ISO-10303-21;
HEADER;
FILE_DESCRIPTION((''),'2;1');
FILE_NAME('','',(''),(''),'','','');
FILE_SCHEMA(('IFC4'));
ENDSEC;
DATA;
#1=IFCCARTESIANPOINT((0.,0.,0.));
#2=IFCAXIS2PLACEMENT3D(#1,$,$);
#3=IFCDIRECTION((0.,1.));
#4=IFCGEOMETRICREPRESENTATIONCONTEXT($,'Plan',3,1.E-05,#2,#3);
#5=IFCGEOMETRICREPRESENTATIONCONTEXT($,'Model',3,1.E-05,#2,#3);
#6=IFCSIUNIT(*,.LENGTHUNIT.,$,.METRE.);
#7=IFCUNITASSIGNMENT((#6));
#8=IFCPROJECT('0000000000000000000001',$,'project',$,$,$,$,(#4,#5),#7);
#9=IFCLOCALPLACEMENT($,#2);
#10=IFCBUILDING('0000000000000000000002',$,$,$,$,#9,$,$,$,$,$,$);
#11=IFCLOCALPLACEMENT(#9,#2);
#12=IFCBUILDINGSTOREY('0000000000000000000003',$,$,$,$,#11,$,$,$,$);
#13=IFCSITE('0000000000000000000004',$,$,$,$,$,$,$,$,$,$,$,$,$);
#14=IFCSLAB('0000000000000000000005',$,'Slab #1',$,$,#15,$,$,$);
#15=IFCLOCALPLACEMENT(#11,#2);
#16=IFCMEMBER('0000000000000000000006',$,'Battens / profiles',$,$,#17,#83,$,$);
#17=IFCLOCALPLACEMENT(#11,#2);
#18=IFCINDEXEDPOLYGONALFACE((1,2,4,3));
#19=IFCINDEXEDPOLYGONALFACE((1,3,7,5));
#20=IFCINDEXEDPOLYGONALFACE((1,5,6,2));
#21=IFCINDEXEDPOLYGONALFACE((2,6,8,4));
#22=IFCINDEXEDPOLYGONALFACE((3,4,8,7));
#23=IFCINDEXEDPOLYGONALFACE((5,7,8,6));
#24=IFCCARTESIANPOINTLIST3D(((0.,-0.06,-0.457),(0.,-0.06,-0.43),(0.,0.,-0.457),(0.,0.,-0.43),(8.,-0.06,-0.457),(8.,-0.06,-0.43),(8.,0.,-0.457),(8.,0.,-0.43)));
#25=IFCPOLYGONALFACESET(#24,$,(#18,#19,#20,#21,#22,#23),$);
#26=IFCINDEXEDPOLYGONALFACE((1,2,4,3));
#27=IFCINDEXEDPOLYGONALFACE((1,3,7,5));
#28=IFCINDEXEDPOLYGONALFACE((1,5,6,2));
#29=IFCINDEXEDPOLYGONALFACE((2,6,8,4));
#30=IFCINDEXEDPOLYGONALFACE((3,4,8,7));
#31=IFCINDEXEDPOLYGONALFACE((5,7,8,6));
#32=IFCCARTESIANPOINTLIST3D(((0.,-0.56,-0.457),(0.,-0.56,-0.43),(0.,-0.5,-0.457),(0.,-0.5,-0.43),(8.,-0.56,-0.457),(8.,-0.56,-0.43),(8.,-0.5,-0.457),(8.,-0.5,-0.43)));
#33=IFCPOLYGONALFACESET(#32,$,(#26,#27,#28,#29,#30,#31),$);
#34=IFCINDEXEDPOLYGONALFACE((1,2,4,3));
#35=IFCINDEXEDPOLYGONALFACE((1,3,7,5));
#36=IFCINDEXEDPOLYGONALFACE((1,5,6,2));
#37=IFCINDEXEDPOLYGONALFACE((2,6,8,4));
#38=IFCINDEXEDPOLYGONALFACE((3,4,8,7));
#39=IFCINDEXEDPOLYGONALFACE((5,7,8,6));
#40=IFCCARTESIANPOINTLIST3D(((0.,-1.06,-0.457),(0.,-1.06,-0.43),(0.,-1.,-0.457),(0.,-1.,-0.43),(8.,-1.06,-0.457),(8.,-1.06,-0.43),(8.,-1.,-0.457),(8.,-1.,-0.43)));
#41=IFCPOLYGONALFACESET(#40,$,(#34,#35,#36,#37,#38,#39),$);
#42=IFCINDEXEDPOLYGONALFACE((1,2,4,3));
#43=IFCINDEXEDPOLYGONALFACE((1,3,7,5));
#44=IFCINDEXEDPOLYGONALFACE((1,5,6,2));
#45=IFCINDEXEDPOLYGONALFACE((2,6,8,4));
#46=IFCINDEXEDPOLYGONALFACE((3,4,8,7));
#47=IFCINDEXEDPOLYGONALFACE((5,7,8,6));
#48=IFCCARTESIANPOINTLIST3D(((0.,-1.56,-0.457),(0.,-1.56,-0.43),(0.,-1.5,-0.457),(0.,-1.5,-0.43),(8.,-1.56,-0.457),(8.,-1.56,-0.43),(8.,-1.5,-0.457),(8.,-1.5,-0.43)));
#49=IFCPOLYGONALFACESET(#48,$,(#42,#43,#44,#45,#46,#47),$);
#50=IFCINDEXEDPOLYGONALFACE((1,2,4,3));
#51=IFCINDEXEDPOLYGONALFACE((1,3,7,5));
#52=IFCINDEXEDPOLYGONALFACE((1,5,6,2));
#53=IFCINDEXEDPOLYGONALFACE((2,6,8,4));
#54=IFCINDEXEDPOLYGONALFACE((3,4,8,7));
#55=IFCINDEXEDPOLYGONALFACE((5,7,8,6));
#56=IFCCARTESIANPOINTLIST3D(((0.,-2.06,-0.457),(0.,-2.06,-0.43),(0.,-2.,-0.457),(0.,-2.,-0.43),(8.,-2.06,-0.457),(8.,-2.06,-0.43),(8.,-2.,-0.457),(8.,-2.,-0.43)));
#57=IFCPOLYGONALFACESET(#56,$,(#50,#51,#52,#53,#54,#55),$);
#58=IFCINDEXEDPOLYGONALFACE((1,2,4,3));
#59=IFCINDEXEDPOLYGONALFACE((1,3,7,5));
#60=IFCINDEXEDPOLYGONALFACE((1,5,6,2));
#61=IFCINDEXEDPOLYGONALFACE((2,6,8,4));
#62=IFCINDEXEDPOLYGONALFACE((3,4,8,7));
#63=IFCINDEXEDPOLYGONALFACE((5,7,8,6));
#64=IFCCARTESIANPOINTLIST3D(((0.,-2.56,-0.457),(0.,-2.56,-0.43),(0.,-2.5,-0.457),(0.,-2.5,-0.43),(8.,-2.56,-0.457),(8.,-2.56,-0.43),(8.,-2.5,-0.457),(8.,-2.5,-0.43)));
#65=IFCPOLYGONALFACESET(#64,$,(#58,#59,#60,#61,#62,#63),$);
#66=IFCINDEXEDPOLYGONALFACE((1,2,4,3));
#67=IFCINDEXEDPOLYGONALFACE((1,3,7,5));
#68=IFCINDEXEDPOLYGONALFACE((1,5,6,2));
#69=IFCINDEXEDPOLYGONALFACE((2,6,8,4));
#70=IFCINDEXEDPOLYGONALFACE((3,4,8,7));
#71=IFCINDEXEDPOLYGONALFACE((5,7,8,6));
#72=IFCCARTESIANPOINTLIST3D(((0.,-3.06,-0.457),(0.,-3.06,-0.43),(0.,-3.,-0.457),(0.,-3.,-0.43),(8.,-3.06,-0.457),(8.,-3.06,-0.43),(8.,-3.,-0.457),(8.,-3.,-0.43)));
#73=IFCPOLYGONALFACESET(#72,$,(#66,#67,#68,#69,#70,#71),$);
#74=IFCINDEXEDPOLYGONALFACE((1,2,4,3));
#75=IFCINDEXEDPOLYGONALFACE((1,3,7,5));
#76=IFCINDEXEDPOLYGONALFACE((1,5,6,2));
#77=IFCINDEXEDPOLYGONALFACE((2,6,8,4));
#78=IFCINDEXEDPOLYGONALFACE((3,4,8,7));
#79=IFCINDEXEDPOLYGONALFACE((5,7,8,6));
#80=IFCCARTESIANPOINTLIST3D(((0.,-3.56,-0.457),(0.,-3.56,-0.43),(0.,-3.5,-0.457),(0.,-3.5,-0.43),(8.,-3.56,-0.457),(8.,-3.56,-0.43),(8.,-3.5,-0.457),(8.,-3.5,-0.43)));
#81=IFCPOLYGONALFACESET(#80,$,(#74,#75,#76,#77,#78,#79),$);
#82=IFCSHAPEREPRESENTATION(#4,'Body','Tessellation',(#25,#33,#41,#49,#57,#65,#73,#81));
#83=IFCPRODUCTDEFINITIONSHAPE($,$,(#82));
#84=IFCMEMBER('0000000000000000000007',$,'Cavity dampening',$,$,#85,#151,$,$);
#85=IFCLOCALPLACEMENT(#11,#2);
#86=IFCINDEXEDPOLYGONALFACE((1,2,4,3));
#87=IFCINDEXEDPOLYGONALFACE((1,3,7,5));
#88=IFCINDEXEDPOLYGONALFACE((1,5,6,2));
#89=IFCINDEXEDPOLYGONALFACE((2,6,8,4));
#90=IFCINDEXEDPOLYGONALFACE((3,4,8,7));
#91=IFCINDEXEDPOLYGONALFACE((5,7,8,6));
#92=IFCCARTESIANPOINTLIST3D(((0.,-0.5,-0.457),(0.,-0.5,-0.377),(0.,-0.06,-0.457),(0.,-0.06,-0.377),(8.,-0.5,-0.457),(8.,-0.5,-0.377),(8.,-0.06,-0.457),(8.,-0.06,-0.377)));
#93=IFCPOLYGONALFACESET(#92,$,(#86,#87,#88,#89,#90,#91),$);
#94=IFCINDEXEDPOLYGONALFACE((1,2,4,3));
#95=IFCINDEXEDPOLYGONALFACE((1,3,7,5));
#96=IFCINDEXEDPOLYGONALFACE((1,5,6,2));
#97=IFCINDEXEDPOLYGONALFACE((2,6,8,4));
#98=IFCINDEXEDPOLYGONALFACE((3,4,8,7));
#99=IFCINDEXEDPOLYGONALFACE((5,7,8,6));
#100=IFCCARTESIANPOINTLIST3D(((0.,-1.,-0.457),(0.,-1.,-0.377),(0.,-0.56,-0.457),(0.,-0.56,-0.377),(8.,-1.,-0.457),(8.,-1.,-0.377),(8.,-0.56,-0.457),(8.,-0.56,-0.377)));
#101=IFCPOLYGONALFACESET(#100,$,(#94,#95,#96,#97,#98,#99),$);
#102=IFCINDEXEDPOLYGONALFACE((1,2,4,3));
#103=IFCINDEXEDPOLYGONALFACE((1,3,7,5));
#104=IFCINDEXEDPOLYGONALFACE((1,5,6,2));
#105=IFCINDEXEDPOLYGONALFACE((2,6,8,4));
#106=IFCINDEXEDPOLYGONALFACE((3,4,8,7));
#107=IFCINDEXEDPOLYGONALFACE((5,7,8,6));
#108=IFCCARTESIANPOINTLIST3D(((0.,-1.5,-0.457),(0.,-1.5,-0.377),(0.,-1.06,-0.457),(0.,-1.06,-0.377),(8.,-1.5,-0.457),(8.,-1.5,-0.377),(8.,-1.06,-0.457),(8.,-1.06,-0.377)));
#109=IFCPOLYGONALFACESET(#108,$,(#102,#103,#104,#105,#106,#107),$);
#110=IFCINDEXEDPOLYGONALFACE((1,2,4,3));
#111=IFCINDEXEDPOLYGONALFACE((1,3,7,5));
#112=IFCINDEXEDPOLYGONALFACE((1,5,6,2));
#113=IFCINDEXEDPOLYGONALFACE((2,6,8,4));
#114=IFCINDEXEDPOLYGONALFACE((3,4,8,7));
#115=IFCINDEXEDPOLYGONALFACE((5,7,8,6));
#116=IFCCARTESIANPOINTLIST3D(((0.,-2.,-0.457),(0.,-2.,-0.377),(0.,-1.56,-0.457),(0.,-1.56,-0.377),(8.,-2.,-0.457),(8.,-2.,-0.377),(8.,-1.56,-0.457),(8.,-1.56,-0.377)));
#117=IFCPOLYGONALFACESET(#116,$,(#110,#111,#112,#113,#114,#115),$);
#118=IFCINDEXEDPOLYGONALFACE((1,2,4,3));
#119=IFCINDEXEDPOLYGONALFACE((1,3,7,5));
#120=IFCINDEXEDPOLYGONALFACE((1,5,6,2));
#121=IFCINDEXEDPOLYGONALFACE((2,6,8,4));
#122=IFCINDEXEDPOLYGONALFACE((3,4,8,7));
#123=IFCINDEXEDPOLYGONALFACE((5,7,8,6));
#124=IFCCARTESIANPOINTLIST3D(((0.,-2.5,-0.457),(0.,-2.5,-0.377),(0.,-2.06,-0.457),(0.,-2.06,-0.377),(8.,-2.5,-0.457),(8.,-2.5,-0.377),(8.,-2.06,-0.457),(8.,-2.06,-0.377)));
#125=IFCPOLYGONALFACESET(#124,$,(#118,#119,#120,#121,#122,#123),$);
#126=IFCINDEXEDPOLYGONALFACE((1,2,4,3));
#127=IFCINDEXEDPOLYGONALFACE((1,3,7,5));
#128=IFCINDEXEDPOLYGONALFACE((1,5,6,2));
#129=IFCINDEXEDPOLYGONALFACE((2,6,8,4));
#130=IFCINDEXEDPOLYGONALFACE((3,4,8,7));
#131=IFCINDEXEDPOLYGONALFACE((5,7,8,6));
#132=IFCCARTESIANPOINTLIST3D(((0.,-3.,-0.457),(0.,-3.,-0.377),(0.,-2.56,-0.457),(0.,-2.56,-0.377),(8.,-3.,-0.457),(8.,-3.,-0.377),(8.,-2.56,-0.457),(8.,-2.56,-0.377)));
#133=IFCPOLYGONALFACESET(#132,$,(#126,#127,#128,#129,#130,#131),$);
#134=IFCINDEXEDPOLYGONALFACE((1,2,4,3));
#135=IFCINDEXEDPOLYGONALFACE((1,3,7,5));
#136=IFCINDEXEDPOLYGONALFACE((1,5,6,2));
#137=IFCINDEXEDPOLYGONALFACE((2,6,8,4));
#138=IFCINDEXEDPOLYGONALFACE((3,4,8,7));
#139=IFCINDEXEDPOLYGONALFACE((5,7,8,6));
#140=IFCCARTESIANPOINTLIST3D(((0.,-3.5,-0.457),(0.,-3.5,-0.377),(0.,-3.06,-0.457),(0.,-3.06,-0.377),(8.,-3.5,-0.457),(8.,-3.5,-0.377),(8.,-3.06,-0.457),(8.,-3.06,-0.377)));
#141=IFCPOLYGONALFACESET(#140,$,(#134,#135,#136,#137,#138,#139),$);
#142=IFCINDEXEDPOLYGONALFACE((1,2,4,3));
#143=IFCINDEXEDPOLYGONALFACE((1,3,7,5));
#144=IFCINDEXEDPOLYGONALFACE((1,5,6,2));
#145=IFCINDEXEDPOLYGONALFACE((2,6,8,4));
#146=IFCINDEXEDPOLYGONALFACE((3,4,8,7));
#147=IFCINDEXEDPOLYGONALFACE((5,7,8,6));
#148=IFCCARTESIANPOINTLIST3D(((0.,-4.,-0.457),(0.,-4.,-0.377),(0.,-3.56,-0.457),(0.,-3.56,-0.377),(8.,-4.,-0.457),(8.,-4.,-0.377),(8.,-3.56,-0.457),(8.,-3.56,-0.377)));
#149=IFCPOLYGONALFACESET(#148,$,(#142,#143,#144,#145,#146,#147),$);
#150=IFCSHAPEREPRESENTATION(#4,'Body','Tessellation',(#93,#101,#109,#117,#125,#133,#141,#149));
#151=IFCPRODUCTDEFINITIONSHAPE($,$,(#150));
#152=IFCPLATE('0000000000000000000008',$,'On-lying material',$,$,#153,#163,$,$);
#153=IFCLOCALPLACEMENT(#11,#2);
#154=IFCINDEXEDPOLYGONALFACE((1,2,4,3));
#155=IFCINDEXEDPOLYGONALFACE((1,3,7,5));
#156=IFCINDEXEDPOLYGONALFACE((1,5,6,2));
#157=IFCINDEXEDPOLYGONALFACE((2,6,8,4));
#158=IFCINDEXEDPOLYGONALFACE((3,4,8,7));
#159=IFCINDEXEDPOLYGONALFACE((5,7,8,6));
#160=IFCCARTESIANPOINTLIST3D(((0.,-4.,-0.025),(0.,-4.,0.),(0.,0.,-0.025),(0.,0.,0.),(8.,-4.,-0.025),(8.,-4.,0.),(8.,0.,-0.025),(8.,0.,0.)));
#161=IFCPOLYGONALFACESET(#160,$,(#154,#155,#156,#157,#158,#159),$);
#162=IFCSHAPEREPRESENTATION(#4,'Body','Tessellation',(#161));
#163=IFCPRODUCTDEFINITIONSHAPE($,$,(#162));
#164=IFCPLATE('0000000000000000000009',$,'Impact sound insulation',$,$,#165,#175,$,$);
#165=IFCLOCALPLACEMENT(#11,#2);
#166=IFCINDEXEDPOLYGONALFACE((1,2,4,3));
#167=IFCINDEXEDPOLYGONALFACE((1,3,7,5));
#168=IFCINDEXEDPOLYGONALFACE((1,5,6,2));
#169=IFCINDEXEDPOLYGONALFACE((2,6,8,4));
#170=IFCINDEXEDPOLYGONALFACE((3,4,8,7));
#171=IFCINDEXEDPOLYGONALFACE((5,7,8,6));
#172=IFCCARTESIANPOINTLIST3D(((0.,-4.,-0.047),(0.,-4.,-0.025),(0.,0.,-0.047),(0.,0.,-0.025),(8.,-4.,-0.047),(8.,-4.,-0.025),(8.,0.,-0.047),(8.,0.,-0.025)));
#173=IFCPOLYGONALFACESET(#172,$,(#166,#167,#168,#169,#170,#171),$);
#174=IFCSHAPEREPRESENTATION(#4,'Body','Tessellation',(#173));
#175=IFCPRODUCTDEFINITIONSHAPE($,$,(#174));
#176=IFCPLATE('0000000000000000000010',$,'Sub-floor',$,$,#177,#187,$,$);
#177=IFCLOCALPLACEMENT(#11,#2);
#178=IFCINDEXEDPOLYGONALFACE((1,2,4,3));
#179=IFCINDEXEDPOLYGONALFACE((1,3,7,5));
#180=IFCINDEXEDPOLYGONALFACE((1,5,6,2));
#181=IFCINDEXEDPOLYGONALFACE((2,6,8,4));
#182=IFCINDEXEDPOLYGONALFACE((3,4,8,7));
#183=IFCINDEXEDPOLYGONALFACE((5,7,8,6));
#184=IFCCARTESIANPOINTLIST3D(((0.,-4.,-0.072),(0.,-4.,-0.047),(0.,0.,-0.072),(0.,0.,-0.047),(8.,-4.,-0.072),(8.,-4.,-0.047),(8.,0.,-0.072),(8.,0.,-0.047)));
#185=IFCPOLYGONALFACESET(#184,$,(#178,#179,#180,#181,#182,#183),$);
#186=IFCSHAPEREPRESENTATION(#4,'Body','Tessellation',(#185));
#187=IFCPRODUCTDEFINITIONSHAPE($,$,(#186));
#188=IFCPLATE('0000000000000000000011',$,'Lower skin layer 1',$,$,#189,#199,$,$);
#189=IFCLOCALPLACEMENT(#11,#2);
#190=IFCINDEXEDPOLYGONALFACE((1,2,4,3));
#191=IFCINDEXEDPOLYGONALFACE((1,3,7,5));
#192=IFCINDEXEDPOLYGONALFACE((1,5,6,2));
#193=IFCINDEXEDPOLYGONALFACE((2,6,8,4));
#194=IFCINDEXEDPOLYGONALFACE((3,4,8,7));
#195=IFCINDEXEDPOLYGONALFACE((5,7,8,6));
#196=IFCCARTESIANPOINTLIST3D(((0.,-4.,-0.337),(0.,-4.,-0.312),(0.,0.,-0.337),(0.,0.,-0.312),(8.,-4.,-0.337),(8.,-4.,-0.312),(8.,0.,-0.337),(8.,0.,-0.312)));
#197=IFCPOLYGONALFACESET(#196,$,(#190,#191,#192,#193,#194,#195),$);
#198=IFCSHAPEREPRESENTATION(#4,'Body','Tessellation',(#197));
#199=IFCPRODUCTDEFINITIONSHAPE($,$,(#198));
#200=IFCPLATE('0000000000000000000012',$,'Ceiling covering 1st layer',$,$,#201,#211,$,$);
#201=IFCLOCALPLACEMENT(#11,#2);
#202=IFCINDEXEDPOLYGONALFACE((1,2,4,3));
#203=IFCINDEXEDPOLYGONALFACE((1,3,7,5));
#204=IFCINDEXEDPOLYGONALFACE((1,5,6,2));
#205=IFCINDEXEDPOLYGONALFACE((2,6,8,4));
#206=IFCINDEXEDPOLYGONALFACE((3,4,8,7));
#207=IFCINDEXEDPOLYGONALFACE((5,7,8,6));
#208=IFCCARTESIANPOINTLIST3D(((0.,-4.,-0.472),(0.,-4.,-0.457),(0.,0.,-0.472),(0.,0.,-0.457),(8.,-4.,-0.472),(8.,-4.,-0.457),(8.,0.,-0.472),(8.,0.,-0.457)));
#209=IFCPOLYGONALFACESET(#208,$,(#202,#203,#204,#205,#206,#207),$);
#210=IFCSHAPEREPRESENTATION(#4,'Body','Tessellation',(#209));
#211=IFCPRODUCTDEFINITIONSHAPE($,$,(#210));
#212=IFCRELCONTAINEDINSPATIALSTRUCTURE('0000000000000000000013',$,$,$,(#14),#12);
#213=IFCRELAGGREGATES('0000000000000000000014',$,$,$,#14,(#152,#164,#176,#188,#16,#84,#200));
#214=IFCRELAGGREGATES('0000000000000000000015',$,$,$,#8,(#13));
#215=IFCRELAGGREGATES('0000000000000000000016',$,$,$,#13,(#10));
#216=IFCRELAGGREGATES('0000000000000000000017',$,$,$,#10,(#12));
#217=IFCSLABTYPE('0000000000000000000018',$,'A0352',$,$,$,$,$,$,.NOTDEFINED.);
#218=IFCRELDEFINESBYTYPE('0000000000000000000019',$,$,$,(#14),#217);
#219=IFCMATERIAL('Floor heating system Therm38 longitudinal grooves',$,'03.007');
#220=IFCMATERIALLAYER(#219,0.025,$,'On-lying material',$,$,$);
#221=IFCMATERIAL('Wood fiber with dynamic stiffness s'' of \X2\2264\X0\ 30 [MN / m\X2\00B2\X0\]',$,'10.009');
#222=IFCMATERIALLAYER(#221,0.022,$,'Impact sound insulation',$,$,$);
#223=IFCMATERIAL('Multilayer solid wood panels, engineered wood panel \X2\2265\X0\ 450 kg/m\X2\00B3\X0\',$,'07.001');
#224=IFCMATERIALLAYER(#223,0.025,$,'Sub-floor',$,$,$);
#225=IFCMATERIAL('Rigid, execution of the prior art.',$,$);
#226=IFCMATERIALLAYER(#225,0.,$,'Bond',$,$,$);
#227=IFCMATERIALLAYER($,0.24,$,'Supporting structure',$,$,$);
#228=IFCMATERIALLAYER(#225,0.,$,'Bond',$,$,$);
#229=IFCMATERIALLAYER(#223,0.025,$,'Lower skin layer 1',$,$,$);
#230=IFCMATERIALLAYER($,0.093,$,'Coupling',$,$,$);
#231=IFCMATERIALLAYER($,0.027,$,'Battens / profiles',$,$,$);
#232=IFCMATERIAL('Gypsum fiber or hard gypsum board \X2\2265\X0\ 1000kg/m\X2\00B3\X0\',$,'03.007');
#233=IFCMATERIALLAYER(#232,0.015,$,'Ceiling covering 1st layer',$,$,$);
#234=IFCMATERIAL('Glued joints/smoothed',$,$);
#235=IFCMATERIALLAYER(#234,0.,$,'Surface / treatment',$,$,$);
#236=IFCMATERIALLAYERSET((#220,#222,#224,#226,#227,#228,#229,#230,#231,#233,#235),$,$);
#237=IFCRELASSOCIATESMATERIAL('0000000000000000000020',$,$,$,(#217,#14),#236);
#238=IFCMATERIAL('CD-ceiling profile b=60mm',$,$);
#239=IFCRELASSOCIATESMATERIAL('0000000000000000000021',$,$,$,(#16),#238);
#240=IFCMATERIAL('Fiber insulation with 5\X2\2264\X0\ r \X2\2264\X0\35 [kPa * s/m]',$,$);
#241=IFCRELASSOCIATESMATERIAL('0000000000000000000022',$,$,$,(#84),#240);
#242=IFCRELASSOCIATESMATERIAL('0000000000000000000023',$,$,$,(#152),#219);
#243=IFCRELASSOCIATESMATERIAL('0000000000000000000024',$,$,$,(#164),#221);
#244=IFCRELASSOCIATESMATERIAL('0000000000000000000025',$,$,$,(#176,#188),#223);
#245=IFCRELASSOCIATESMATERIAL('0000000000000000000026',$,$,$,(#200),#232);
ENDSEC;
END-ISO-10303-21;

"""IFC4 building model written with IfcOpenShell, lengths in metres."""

from ifc_helpers import new_model, si_unit, direction, frame, frame_2d, origin, origin_with_axes, place, context, project, spatial, rectangle, extrude, material, layer, layer_set, type_object, element, aggregate, save


model = new_model("IFC4")

# Units and contexts
plan_context = context("Plan", 3, precision=1e-05, world=origin(), true_north=direction((0.0, 1.0)))
model_context = context("Model", 3, precision=1e-05, world=origin(), true_north=direction((0.0, 1.0)))
ifc_project = project(units=[si_unit("LENGTHUNIT", "METRE")], contexts=[plan_context, model_context])

# Site, building, storey
site = spatial("IfcSite", under=ifc_project)
building_placement = place(None, origin())
building = spatial("IfcBuilding", under=site, at=building_placement)
storey_placement = place(building_placement, origin())
storey = spatial("IfcBuildingStorey", under=building, at=storey_placement)

# Slab, members, plates
ifc_material_1 = material(Name="Floor heating system Therm38 longitudinal grooves", Category="03.007")
ifc_layer_1 = layer(ifc_material_1, 0.025, Name="On-lying material")
ifc_material_2 = material(Name="Wood fiber with dynamic stiffness s' of ≤ 30 [MN / m²]", Category="10.009")
ifc_layer_2 = layer(ifc_material_2, 0.022, Name="Impact sound insulation")
ifc_material_3 = material(Name="Multilayer solid wood panels, engineered wood panel ≥ 450 kg/m³", Category="07.001")
ifc_layer_3 = layer(ifc_material_3, 0.025, Name="Sub-floor")
ifc_material_4 = material(Name="Rigid, execution of the prior art.")
ifc_layer_4 = layer(ifc_material_4, 0.0, Name="Bond")
ifc_layer_5 = layer(None, 0.24, Name="Supporting structure")
ifc_layer_6 = layer(ifc_material_4, 0.0, Name="Bond")
ifc_layer_7 = layer(ifc_material_3, 0.025, Name="Lower skin layer 1")
ifc_layer_8 = layer(None, 0.093, Name="Coupling")
ifc_layer_9 = layer(None, 0.027, Name="Battens / profiles")
ifc_material_5 = material(Name="Gypsum fiber or hard gypsum board ≥ 1000kg/m³", Category="03.007")
ifc_layer_10 = layer(ifc_material_5, 0.015, Name="Ceiling covering 1st layer")
ifc_material_6 = material(Name="Glued joints/smoothed")
ifc_layer_11 = layer(ifc_material_6, 0.0, Name="Surface / treatment")
ifc_layer_set = layer_set([ifc_layer_1, ifc_layer_2, ifc_layer_3, ifc_layer_4, ifc_layer_5, ifc_layer_6, ifc_layer_7, ifc_layer_8, ifc_layer_9, ifc_layer_10, ifc_layer_11])
slab_type = type_object("IfcSlabType", Name="A0352", PredefinedType="NOTDEFINED", material=ifc_layer_set)
slab_placement = place(None, frame((0.0, 0.0, 0.0), z_axis=(0.0, 0.0, -1.0), x_axis=(1.0, 0.0, 0.0)))
slab = element("IfcSlab", 1, at=slab_placement, inside=storey, type_object=slab_type, material=ifc_layer_set, Name="Slab #1")
ifc_material_7 = material(Name="Fiber insulation with 5≤ r ≤35 [kPa * s/m]")
ifc_material_8 = material(Name="CD-ceiling profile b=60mm")
member_1_placement = place(slab_placement, origin())
member_1 = element("IfcMember", 2, at=member_1_placement, material=ifc_material_8, Name="Battens / profiles", context=plan_context, shape_type="SweptSolid", body=[
    extrude(rectangle(XDim=0.06, YDim=0.027, at=frame_2d((0.03, 0.0135), x_axis=(1.0, 0.0))), frame((0.0, 0.0, 0.43), z_axis=(1.0, 0.0, 0.0), x_axis=(0.0, 1.0, 0.0)), (0.0, 0.0, 1.0), 8.0),
    extrude(rectangle(XDim=0.06, YDim=0.027, at=frame_2d((0.03, 0.0135), x_axis=(1.0, 0.0))), frame((0.0, 0.5, 0.43), z_axis=(1.0, 0.0, 0.0), x_axis=(0.0, 1.0, 0.0)), (0.0, 0.0, 1.0), 8.0),
    extrude(rectangle(XDim=0.06, YDim=0.027, at=frame_2d((0.03, 0.0135), x_axis=(1.0, 0.0))), frame((0.0, 1.0, 0.43), z_axis=(1.0, 0.0, 0.0), x_axis=(0.0, 1.0, 0.0)), (0.0, 0.0, 1.0), 8.0),
    extrude(rectangle(XDim=0.06, YDim=0.027, at=frame_2d((0.03, 0.0135), x_axis=(1.0, 0.0))), frame((0.0, 1.5, 0.43), z_axis=(1.0, 0.0, 0.0), x_axis=(0.0, 1.0, 0.0)), (0.0, 0.0, 1.0), 8.0),
    extrude(rectangle(XDim=0.06, YDim=0.027, at=frame_2d((0.03, 0.0135), x_axis=(1.0, 0.0))), frame((0.0, 2.0, 0.43), z_axis=(1.0, 0.0, 0.0), x_axis=(0.0, 1.0, 0.0)), (0.0, 0.0, 1.0), 8.0),
    extrude(rectangle(XDim=0.06, YDim=0.027, at=frame_2d((0.03, 0.0135), x_axis=(1.0, 0.0))), frame((0.0, 2.5, 0.43), z_axis=(1.0, 0.0, 0.0), x_axis=(0.0, 1.0, 0.0)), (0.0, 0.0, 1.0), 8.0),
    extrude(rectangle(XDim=0.06, YDim=0.027, at=frame_2d((0.03, 0.0135), x_axis=(1.0, 0.0))), frame((0.0, 3.0, 0.43), z_axis=(1.0, 0.0, 0.0), x_axis=(0.0, 1.0, 0.0)), (0.0, 0.0, 1.0), 8.0),
    extrude(rectangle(XDim=0.06, YDim=0.027, at=frame_2d((0.03, 0.0135), x_axis=(1.0, 0.0))), frame((0.0, 3.5, 0.43), z_axis=(1.0, 0.0, 0.0), x_axis=(0.0, 1.0, 0.0)), (0.0, 0.0, 1.0), 8.0),
])
member_2_placement = place(slab_placement, origin())
member_2 = element("IfcMember", 3, at=member_2_placement, material=ifc_material_7, Name="Cavity dampening", context=plan_context, shape_type="SweptSolid", body=[
    extrude(rectangle(XDim=0.44, YDim=0.08, at=frame_2d((0.22, 0.04), x_axis=(1.0, 0.0))), frame((0.0, 0.06, 0.377), z_axis=(1.0, 0.0, 0.0), x_axis=(0.0, 1.0, 0.0)), (0.0, 0.0, 1.0), 8.0),
    extrude(rectangle(XDim=0.44, YDim=0.08, at=frame_2d((0.22, 0.04), x_axis=(1.0, 0.0))), frame((0.0, 0.56, 0.377), z_axis=(1.0, 0.0, 0.0), x_axis=(0.0, 1.0, 0.0)), (0.0, 0.0, 1.0), 8.0),
    extrude(rectangle(XDim=0.44, YDim=0.08, at=frame_2d((0.22, 0.04), x_axis=(1.0, 0.0))), frame((0.0, 1.06, 0.377), z_axis=(1.0, 0.0, 0.0), x_axis=(0.0, 1.0, 0.0)), (0.0, 0.0, 1.0), 8.0),
    extrude(rectangle(XDim=0.44, YDim=0.08, at=frame_2d((0.22, 0.04), x_axis=(1.0, 0.0))), frame((0.0, 1.56, 0.377), z_axis=(1.0, 0.0, 0.0), x_axis=(0.0, 1.0, 0.0)), (0.0, 0.0, 1.0), 8.0),
    extrude(rectangle(XDim=0.44, YDim=0.08, at=frame_2d((0.22, 0.04), x_axis=(1.0, 0.0))), frame((0.0, 2.06, 0.377), z_axis=(1.0, 0.0, 0.0), x_axis=(0.0, 1.0, 0.0)), (0.0, 0.0, 1.0), 8.0),
    extrude(rectangle(XDim=0.44, YDim=0.08, at=frame_2d((0.22, 0.04), x_axis=(1.0, 0.0))), frame((0.0, 2.56, 0.377), z_axis=(1.0, 0.0, 0.0), x_axis=(0.0, 1.0, 0.0)), (0.0, 0.0, 1.0), 8.0),
    extrude(rectangle(XDim=0.44, YDim=0.08, at=frame_2d((0.22, 0.04), x_axis=(1.0, 0.0))), frame((0.0, 3.06, 0.377), z_axis=(1.0, 0.0, 0.0), x_axis=(0.0, 1.0, 0.0)), (0.0, 0.0, 1.0), 8.0),
    extrude(rectangle(XDim=0.44, YDim=0.08, at=frame_2d((0.22, 0.04), x_axis=(1.0, 0.0))), frame((0.0, 3.56, 0.377), z_axis=(1.0, 0.0, 0.0), x_axis=(0.0, 1.0, 0.0)), (0.0, 0.0, 1.0), 8.0),
])
plate_1_placement = place(slab_placement, origin())
plate_1 = element("IfcPlate", 4, at=plate_1_placement, material=ifc_material_1, Name="On-lying material", context=plan_context, shape_type="SweptSolid", body=[
    extrude(rectangle(XDim=8.0, YDim=4.0, at=frame_2d((4.0, 2.0), x_axis=(1.0, 0.0))), origin_with_axes(), (0.0, 0.0, 1.0), 0.025),
])
plate_2_placement = place(slab_placement, origin())
plate_2 = element("IfcPlate", 5, at=plate_2_placement, material=ifc_material_2, Name="Impact sound insulation", context=plan_context, shape_type="SweptSolid", body=[
    extrude(rectangle(XDim=8.0, YDim=4.0, at=frame_2d((4.0, 2.0), x_axis=(1.0, 0.0))), frame((0.0, 0.0, 0.025), z_axis=(0.0, 0.0, 1.0), x_axis=(1.0, 0.0, 0.0)), (0.0, 0.0, 1.0), 0.022),
])
plate_3_placement = place(slab_placement, origin())
plate_3 = element("IfcPlate", 6, at=plate_3_placement, material=ifc_material_3, Name="Sub-floor", context=plan_context, shape_type="SweptSolid", body=[
    extrude(rectangle(XDim=8.0, YDim=4.0, at=frame_2d((4.0, 2.0), x_axis=(1.0, 0.0))), frame((0.0, 0.0, 0.047), z_axis=(0.0, 0.0, 1.0), x_axis=(1.0, 0.0, 0.0)), (0.0, 0.0, 1.0), 0.025),
])
plate_4_placement = place(slab_placement, origin())
plate_4 = element("IfcPlate", 7, at=plate_4_placement, material=ifc_material_3, Name="Lower skin layer 1", context=plan_context, shape_type="SweptSolid", body=[
    extrude(rectangle(XDim=8.0, YDim=4.0, at=frame_2d((4.0, 2.0), x_axis=(1.0, 0.0))), frame((0.0, 0.0, 0.312), z_axis=(0.0, 0.0, 1.0), x_axis=(1.0, 0.0, 0.0)), (0.0, 0.0, 1.0), 0.025),
])
plate_5_placement = place(slab_placement, origin())
plate_5 = element("IfcPlate", 8, at=plate_5_placement, material=ifc_material_5, Name="Ceiling covering 1st layer", context=plan_context, shape_type="SweptSolid", body=[
    extrude(rectangle(XDim=8.0, YDim=4.0, at=frame_2d((4.0, 2.0), x_axis=(1.0, 0.0))), frame((0.0, 0.0, 0.457), z_axis=(0.0, 0.0, 1.0), x_axis=(1.0, 0.0, 0.0)), (0.0, 0.0, 1.0), 0.015),
])
aggregate(slab, [plate_1, plate_2, plate_3, plate_4, member_1, member_2, plate_5])

save(model, "model.ifc")
